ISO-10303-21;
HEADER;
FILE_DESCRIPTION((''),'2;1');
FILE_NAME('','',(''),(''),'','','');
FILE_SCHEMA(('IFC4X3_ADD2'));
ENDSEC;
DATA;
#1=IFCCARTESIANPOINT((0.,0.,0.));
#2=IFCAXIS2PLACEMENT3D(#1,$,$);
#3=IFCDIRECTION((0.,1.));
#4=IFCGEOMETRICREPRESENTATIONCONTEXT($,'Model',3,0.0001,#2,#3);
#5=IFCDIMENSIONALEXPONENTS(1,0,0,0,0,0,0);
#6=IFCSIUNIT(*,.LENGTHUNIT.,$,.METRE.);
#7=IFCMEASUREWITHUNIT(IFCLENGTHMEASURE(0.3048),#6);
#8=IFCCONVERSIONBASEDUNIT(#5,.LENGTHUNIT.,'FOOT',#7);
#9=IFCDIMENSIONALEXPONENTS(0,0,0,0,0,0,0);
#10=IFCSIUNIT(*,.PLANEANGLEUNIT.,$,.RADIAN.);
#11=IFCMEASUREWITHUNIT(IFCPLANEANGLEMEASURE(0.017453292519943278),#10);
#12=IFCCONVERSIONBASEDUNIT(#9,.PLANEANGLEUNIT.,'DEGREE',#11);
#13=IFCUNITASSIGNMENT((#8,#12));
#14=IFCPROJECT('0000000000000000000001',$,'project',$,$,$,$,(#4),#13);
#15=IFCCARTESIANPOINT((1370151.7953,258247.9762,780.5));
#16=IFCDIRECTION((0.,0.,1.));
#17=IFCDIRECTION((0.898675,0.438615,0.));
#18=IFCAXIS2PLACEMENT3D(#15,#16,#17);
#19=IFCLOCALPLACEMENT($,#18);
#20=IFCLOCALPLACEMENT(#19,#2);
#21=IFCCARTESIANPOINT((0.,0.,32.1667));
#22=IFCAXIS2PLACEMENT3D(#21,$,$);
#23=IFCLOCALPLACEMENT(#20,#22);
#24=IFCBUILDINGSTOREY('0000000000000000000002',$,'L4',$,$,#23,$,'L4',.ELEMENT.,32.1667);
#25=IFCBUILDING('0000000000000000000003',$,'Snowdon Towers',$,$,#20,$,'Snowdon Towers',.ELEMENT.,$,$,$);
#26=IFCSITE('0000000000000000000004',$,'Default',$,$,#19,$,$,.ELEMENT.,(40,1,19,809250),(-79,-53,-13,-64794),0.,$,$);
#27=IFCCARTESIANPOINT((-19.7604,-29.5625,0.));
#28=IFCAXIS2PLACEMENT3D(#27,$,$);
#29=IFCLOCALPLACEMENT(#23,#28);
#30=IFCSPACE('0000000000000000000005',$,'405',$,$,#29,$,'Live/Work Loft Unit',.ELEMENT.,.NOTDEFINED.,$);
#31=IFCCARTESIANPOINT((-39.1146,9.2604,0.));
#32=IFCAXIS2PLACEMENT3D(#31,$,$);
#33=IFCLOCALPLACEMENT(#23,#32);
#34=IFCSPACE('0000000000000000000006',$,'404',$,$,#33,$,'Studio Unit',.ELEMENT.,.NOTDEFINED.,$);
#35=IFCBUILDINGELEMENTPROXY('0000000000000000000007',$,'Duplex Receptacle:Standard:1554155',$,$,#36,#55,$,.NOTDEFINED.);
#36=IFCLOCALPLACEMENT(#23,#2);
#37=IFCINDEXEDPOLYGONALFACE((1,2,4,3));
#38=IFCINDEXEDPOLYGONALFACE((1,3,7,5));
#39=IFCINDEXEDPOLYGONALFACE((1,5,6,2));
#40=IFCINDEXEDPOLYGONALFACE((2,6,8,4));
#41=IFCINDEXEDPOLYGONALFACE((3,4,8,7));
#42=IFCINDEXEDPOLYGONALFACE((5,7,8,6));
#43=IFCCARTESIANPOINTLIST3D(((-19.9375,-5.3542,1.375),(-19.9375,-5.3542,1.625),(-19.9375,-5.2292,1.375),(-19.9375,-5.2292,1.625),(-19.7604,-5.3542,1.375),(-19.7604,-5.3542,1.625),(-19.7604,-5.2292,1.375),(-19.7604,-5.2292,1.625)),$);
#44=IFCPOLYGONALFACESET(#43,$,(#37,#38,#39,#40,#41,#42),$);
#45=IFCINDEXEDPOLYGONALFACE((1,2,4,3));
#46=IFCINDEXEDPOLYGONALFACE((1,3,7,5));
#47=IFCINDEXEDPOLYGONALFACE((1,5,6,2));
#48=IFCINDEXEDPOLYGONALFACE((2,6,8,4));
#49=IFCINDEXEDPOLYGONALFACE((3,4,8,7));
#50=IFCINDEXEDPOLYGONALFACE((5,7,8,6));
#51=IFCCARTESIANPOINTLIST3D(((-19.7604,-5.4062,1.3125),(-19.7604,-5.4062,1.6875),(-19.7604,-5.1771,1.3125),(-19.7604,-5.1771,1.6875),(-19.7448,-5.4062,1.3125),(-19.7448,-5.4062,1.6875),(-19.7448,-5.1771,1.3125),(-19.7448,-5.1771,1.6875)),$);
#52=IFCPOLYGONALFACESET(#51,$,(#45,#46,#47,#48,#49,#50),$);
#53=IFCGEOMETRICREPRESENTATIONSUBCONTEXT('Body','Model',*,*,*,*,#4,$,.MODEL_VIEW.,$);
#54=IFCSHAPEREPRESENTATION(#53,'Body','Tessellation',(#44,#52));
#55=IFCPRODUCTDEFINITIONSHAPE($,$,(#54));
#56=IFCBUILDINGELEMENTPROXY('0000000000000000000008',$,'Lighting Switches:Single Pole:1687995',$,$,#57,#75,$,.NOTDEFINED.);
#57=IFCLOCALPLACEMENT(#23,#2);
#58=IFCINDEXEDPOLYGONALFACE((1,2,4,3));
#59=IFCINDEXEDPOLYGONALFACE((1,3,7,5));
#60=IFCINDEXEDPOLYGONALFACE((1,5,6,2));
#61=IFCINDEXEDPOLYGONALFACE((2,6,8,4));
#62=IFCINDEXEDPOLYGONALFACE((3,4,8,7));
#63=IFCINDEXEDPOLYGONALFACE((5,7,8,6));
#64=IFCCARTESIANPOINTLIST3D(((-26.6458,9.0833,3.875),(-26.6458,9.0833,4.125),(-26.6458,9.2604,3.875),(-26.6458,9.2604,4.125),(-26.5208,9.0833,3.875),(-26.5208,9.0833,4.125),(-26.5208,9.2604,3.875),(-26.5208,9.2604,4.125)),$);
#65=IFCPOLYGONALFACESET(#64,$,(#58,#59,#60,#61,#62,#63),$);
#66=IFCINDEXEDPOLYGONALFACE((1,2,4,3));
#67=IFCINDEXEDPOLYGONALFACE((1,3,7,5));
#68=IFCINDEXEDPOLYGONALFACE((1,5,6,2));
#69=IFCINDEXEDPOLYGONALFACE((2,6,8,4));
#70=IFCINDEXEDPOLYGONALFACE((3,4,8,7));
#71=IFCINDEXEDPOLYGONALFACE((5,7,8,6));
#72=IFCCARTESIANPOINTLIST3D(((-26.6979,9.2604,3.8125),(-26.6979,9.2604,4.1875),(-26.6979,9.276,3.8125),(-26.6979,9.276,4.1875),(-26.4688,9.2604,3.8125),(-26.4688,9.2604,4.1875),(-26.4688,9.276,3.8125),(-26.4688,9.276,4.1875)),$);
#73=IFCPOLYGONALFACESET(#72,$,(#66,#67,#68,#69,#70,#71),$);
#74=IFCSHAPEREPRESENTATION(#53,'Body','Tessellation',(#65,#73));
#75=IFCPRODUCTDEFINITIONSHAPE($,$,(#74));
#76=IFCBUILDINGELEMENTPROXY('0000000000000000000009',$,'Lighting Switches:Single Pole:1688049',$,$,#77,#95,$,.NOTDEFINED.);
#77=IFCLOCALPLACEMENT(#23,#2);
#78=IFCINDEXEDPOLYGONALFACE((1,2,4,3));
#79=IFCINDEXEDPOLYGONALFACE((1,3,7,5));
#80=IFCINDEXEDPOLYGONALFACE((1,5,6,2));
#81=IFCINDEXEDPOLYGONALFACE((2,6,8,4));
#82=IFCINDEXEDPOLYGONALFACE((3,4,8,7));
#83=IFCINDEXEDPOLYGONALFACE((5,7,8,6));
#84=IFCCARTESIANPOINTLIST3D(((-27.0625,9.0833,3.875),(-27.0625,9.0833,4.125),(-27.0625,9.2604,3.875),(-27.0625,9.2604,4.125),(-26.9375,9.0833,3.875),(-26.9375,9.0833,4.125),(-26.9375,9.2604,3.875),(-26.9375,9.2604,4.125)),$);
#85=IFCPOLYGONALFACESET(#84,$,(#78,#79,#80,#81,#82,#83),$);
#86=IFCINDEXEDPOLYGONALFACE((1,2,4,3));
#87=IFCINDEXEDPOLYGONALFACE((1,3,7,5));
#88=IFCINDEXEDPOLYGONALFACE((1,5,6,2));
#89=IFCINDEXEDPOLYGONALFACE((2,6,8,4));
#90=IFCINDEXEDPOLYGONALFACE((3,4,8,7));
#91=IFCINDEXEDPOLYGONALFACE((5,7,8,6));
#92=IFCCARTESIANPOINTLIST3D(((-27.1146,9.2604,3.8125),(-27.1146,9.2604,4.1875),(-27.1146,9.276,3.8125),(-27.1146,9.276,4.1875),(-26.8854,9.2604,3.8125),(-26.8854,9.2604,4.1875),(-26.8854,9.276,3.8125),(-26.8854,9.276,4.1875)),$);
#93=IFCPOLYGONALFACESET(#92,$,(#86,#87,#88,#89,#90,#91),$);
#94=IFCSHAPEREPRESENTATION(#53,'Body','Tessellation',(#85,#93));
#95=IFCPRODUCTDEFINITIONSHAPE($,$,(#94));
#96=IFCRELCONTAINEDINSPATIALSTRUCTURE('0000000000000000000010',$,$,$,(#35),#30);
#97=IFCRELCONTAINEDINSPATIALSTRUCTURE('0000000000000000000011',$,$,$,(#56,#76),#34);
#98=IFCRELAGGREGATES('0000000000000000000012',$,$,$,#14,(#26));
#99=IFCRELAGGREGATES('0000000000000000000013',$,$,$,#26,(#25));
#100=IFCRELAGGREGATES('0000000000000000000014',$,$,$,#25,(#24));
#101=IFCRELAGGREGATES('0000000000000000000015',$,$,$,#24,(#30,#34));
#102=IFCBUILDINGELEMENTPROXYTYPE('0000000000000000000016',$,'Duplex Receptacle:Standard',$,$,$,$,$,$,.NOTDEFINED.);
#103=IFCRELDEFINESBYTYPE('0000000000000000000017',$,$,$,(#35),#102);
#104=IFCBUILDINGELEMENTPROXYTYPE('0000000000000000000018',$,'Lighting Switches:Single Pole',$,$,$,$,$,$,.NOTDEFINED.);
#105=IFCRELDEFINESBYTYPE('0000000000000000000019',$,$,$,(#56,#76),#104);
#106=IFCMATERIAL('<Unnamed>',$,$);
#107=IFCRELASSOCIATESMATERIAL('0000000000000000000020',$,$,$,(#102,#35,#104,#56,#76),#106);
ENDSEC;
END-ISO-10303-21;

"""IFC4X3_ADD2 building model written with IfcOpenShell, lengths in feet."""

from ifc_helpers import new_model, entity, si_unit, converted_unit, direction, frame, frame_2d, origin, origin_2d_with_axis, place, context, subcontext, project, spatial, rectangle, extrude, source, transform, mapped, material, type_object, type_shapes, element, save


model = new_model("IFC4X3_ADD2")

# Units and contexts
model_context = context("Model", 3, precision=0.0001, world=origin(), true_north=direction((0.0, 1.0)))
body_context = subcontext(model_context, "Body", "Model", "MODEL_VIEW")
ifc_project = project(units=[converted_unit("LENGTHUNIT", "FOOT", entity("IfcLengthMeasure", 0.3048), si_unit("LENGTHUNIT", "METRE"), dimensions=[1, 0, 0, 0, 0, 0, 0]), converted_unit("PLANEANGLEUNIT", "DEGREE", entity("IfcPlaneAngleMeasure", 0.017453292519943278), si_unit("PLANEANGLEUNIT", "RADIAN"), dimensions=[0, 0, 0, 0, 0, 0, 0])], contexts=[model_context])

# Site, building, storey
site_placement = place(None, frame((1370151.7953, 258247.9762, 780.5), z_axis=(0.0, 0.0, 1.0), x_axis=(0.898675, 0.438615, 0.0)))
site = spatial("IfcSite", under=ifc_project, at=site_placement, Name="Default", CompositionType="ELEMENT", RefLatitude=(40, 1, 19, 809250), RefLongitude=(-79, -53, -13, -64794), RefElevation=0.0)
building_placement = place(site_placement, origin())
building = spatial("IfcBuilding", under=site, at=building_placement, Name="Snowdon Towers", LongName="Snowdon Towers", CompositionType="ELEMENT")
storey_placement = place(building_placement, frame((0.0, 0.0, 32.1667)))
storey = spatial("IfcBuildingStorey", under=building, at=storey_placement, Name="L4", LongName="L4", CompositionType="ELEMENT", Elevation=32.1667)

# Shared definitions
space_1_placement = place(storey_placement, frame((-19.7604, -29.5625, 0.0)))
space_1 = spatial("IfcSpace", under=storey, at=space_1_placement, Name="405", LongName="Live/Work Loft Unit", CompositionType="ELEMENT", PredefinedType="NOTDEFINED")

# Building element proxy
ifc_material_1 = material(Name="<Unnamed>")
building_element_proxy_type_1 = type_object("IfcBuildingElementProxyType", Name="Duplex Receptacle:Standard", PredefinedType="NOTDEFINED", material=ifc_material_1)
shared_shape_1 = source(origin(), body_context, "Body", "SweptSolid", [
    extrude(rectangle(XDim=0.125, YDim=0.25, at=origin_2d_with_axis()), frame((0.0, 0.0, -0.1771), z_axis=(0.0, 0.0, 1.0), x_axis=(-1.0, 0.0, 0.0)), (0.0, 0.0, 1.0), 0.1771),
    extrude(rectangle(XDim=0.2292, YDim=0.375, at=frame_2d((0.0, 0.0), x_axis=(1.0, 0.0))), frame((0.0, 0.0, 0.0), z_axis=(0.0, 0.0, 1.0), x_axis=(-1.0, 0.0, 0.0)), (0.0, 0.0, 1.0), 0.0156),
])
type_shapes(building_element_proxy_type_1, [shared_shape_1])
for number, where, z_axis, x_axis, name in (
    (1, (0.0, 24.2708, 1.5), (1.0, 0.0, 0.0), (0.0, 1.0, 0.0), "Duplex Receptacle:Standard:1554155"),
):
    element("IfcBuildingElementProxy", number, at=place(space_1_placement, frame(where, z_axis=z_axis, x_axis=x_axis)), inside=space_1, type_object=building_element_proxy_type_1, material=ifc_material_1, Name=name, PredefinedType="NOTDEFINED", context=body_context, shape_type="MappedRepresentation", body=[
        mapped(shared_shape_1, transform((0.0, 0.0, 0.0), scale=1.0)),
    ])

# Shared definitions
space_2_placement = place(storey_placement, frame((-39.1146, 9.2604, 0.0)))
space_2 = spatial("IfcSpace", under=storey, at=space_2_placement, Name="404", LongName="Studio Unit", CompositionType="ELEMENT", PredefinedType="NOTDEFINED")

# Building element proxies
building_element_proxy_type_2 = type_object("IfcBuildingElementProxyType", Name="Lighting Switches:Single Pole", PredefinedType="NOTDEFINED", material=ifc_material_1)
shared_shape_2 = source(origin(), body_context, "Body", "SweptSolid", [
    extrude(rectangle(XDim=0.125, YDim=0.25, at=origin_2d_with_axis()), frame((0.0, 0.0, -0.1771), z_axis=(0.0, 0.0, 1.0), x_axis=(-1.0, 0.0, 0.0)), (0.0, 0.0, 1.0), 0.1771),
    extrude(rectangle(XDim=0.2292, YDim=0.375, at=frame_2d((0.0, 0.0), x_axis=(1.0, 0.0))), frame((0.0, 0.0, 0.0), z_axis=(0.0, 0.0, 1.0), x_axis=(-1.0, 0.0, 0.0)), (0.0, 0.0, 1.0), 0.0156),
])
type_shapes(building_element_proxy_type_2, [shared_shape_2])
for number, where, z_axis, x_axis, name in (
    (2, (12.5313, 0.0, 4.0), (0.0, 1.0, 0.0), (-1.0, 0.0, 0.0), "Lighting Switches:Single Pole:1687995"),
    (3, (12.1146, 0.0, 4.0), (0.0, 1.0, 0.0), (-1.0, 0.0, 0.0), "Lighting Switches:Single Pole:1688049"),
):
    element("IfcBuildingElementProxy", number, at=place(space_2_placement, frame(where, z_axis=z_axis, x_axis=x_axis)), inside=space_2, type_object=building_element_proxy_type_2, material=ifc_material_1, Name=name, PredefinedType="NOTDEFINED", context=body_context, shape_type="MappedRepresentation", body=[
        mapped(shared_shape_2, transform((0.0, 0.0, 0.0), scale=1.0)),
    ])

save(model, "model.ifc")
